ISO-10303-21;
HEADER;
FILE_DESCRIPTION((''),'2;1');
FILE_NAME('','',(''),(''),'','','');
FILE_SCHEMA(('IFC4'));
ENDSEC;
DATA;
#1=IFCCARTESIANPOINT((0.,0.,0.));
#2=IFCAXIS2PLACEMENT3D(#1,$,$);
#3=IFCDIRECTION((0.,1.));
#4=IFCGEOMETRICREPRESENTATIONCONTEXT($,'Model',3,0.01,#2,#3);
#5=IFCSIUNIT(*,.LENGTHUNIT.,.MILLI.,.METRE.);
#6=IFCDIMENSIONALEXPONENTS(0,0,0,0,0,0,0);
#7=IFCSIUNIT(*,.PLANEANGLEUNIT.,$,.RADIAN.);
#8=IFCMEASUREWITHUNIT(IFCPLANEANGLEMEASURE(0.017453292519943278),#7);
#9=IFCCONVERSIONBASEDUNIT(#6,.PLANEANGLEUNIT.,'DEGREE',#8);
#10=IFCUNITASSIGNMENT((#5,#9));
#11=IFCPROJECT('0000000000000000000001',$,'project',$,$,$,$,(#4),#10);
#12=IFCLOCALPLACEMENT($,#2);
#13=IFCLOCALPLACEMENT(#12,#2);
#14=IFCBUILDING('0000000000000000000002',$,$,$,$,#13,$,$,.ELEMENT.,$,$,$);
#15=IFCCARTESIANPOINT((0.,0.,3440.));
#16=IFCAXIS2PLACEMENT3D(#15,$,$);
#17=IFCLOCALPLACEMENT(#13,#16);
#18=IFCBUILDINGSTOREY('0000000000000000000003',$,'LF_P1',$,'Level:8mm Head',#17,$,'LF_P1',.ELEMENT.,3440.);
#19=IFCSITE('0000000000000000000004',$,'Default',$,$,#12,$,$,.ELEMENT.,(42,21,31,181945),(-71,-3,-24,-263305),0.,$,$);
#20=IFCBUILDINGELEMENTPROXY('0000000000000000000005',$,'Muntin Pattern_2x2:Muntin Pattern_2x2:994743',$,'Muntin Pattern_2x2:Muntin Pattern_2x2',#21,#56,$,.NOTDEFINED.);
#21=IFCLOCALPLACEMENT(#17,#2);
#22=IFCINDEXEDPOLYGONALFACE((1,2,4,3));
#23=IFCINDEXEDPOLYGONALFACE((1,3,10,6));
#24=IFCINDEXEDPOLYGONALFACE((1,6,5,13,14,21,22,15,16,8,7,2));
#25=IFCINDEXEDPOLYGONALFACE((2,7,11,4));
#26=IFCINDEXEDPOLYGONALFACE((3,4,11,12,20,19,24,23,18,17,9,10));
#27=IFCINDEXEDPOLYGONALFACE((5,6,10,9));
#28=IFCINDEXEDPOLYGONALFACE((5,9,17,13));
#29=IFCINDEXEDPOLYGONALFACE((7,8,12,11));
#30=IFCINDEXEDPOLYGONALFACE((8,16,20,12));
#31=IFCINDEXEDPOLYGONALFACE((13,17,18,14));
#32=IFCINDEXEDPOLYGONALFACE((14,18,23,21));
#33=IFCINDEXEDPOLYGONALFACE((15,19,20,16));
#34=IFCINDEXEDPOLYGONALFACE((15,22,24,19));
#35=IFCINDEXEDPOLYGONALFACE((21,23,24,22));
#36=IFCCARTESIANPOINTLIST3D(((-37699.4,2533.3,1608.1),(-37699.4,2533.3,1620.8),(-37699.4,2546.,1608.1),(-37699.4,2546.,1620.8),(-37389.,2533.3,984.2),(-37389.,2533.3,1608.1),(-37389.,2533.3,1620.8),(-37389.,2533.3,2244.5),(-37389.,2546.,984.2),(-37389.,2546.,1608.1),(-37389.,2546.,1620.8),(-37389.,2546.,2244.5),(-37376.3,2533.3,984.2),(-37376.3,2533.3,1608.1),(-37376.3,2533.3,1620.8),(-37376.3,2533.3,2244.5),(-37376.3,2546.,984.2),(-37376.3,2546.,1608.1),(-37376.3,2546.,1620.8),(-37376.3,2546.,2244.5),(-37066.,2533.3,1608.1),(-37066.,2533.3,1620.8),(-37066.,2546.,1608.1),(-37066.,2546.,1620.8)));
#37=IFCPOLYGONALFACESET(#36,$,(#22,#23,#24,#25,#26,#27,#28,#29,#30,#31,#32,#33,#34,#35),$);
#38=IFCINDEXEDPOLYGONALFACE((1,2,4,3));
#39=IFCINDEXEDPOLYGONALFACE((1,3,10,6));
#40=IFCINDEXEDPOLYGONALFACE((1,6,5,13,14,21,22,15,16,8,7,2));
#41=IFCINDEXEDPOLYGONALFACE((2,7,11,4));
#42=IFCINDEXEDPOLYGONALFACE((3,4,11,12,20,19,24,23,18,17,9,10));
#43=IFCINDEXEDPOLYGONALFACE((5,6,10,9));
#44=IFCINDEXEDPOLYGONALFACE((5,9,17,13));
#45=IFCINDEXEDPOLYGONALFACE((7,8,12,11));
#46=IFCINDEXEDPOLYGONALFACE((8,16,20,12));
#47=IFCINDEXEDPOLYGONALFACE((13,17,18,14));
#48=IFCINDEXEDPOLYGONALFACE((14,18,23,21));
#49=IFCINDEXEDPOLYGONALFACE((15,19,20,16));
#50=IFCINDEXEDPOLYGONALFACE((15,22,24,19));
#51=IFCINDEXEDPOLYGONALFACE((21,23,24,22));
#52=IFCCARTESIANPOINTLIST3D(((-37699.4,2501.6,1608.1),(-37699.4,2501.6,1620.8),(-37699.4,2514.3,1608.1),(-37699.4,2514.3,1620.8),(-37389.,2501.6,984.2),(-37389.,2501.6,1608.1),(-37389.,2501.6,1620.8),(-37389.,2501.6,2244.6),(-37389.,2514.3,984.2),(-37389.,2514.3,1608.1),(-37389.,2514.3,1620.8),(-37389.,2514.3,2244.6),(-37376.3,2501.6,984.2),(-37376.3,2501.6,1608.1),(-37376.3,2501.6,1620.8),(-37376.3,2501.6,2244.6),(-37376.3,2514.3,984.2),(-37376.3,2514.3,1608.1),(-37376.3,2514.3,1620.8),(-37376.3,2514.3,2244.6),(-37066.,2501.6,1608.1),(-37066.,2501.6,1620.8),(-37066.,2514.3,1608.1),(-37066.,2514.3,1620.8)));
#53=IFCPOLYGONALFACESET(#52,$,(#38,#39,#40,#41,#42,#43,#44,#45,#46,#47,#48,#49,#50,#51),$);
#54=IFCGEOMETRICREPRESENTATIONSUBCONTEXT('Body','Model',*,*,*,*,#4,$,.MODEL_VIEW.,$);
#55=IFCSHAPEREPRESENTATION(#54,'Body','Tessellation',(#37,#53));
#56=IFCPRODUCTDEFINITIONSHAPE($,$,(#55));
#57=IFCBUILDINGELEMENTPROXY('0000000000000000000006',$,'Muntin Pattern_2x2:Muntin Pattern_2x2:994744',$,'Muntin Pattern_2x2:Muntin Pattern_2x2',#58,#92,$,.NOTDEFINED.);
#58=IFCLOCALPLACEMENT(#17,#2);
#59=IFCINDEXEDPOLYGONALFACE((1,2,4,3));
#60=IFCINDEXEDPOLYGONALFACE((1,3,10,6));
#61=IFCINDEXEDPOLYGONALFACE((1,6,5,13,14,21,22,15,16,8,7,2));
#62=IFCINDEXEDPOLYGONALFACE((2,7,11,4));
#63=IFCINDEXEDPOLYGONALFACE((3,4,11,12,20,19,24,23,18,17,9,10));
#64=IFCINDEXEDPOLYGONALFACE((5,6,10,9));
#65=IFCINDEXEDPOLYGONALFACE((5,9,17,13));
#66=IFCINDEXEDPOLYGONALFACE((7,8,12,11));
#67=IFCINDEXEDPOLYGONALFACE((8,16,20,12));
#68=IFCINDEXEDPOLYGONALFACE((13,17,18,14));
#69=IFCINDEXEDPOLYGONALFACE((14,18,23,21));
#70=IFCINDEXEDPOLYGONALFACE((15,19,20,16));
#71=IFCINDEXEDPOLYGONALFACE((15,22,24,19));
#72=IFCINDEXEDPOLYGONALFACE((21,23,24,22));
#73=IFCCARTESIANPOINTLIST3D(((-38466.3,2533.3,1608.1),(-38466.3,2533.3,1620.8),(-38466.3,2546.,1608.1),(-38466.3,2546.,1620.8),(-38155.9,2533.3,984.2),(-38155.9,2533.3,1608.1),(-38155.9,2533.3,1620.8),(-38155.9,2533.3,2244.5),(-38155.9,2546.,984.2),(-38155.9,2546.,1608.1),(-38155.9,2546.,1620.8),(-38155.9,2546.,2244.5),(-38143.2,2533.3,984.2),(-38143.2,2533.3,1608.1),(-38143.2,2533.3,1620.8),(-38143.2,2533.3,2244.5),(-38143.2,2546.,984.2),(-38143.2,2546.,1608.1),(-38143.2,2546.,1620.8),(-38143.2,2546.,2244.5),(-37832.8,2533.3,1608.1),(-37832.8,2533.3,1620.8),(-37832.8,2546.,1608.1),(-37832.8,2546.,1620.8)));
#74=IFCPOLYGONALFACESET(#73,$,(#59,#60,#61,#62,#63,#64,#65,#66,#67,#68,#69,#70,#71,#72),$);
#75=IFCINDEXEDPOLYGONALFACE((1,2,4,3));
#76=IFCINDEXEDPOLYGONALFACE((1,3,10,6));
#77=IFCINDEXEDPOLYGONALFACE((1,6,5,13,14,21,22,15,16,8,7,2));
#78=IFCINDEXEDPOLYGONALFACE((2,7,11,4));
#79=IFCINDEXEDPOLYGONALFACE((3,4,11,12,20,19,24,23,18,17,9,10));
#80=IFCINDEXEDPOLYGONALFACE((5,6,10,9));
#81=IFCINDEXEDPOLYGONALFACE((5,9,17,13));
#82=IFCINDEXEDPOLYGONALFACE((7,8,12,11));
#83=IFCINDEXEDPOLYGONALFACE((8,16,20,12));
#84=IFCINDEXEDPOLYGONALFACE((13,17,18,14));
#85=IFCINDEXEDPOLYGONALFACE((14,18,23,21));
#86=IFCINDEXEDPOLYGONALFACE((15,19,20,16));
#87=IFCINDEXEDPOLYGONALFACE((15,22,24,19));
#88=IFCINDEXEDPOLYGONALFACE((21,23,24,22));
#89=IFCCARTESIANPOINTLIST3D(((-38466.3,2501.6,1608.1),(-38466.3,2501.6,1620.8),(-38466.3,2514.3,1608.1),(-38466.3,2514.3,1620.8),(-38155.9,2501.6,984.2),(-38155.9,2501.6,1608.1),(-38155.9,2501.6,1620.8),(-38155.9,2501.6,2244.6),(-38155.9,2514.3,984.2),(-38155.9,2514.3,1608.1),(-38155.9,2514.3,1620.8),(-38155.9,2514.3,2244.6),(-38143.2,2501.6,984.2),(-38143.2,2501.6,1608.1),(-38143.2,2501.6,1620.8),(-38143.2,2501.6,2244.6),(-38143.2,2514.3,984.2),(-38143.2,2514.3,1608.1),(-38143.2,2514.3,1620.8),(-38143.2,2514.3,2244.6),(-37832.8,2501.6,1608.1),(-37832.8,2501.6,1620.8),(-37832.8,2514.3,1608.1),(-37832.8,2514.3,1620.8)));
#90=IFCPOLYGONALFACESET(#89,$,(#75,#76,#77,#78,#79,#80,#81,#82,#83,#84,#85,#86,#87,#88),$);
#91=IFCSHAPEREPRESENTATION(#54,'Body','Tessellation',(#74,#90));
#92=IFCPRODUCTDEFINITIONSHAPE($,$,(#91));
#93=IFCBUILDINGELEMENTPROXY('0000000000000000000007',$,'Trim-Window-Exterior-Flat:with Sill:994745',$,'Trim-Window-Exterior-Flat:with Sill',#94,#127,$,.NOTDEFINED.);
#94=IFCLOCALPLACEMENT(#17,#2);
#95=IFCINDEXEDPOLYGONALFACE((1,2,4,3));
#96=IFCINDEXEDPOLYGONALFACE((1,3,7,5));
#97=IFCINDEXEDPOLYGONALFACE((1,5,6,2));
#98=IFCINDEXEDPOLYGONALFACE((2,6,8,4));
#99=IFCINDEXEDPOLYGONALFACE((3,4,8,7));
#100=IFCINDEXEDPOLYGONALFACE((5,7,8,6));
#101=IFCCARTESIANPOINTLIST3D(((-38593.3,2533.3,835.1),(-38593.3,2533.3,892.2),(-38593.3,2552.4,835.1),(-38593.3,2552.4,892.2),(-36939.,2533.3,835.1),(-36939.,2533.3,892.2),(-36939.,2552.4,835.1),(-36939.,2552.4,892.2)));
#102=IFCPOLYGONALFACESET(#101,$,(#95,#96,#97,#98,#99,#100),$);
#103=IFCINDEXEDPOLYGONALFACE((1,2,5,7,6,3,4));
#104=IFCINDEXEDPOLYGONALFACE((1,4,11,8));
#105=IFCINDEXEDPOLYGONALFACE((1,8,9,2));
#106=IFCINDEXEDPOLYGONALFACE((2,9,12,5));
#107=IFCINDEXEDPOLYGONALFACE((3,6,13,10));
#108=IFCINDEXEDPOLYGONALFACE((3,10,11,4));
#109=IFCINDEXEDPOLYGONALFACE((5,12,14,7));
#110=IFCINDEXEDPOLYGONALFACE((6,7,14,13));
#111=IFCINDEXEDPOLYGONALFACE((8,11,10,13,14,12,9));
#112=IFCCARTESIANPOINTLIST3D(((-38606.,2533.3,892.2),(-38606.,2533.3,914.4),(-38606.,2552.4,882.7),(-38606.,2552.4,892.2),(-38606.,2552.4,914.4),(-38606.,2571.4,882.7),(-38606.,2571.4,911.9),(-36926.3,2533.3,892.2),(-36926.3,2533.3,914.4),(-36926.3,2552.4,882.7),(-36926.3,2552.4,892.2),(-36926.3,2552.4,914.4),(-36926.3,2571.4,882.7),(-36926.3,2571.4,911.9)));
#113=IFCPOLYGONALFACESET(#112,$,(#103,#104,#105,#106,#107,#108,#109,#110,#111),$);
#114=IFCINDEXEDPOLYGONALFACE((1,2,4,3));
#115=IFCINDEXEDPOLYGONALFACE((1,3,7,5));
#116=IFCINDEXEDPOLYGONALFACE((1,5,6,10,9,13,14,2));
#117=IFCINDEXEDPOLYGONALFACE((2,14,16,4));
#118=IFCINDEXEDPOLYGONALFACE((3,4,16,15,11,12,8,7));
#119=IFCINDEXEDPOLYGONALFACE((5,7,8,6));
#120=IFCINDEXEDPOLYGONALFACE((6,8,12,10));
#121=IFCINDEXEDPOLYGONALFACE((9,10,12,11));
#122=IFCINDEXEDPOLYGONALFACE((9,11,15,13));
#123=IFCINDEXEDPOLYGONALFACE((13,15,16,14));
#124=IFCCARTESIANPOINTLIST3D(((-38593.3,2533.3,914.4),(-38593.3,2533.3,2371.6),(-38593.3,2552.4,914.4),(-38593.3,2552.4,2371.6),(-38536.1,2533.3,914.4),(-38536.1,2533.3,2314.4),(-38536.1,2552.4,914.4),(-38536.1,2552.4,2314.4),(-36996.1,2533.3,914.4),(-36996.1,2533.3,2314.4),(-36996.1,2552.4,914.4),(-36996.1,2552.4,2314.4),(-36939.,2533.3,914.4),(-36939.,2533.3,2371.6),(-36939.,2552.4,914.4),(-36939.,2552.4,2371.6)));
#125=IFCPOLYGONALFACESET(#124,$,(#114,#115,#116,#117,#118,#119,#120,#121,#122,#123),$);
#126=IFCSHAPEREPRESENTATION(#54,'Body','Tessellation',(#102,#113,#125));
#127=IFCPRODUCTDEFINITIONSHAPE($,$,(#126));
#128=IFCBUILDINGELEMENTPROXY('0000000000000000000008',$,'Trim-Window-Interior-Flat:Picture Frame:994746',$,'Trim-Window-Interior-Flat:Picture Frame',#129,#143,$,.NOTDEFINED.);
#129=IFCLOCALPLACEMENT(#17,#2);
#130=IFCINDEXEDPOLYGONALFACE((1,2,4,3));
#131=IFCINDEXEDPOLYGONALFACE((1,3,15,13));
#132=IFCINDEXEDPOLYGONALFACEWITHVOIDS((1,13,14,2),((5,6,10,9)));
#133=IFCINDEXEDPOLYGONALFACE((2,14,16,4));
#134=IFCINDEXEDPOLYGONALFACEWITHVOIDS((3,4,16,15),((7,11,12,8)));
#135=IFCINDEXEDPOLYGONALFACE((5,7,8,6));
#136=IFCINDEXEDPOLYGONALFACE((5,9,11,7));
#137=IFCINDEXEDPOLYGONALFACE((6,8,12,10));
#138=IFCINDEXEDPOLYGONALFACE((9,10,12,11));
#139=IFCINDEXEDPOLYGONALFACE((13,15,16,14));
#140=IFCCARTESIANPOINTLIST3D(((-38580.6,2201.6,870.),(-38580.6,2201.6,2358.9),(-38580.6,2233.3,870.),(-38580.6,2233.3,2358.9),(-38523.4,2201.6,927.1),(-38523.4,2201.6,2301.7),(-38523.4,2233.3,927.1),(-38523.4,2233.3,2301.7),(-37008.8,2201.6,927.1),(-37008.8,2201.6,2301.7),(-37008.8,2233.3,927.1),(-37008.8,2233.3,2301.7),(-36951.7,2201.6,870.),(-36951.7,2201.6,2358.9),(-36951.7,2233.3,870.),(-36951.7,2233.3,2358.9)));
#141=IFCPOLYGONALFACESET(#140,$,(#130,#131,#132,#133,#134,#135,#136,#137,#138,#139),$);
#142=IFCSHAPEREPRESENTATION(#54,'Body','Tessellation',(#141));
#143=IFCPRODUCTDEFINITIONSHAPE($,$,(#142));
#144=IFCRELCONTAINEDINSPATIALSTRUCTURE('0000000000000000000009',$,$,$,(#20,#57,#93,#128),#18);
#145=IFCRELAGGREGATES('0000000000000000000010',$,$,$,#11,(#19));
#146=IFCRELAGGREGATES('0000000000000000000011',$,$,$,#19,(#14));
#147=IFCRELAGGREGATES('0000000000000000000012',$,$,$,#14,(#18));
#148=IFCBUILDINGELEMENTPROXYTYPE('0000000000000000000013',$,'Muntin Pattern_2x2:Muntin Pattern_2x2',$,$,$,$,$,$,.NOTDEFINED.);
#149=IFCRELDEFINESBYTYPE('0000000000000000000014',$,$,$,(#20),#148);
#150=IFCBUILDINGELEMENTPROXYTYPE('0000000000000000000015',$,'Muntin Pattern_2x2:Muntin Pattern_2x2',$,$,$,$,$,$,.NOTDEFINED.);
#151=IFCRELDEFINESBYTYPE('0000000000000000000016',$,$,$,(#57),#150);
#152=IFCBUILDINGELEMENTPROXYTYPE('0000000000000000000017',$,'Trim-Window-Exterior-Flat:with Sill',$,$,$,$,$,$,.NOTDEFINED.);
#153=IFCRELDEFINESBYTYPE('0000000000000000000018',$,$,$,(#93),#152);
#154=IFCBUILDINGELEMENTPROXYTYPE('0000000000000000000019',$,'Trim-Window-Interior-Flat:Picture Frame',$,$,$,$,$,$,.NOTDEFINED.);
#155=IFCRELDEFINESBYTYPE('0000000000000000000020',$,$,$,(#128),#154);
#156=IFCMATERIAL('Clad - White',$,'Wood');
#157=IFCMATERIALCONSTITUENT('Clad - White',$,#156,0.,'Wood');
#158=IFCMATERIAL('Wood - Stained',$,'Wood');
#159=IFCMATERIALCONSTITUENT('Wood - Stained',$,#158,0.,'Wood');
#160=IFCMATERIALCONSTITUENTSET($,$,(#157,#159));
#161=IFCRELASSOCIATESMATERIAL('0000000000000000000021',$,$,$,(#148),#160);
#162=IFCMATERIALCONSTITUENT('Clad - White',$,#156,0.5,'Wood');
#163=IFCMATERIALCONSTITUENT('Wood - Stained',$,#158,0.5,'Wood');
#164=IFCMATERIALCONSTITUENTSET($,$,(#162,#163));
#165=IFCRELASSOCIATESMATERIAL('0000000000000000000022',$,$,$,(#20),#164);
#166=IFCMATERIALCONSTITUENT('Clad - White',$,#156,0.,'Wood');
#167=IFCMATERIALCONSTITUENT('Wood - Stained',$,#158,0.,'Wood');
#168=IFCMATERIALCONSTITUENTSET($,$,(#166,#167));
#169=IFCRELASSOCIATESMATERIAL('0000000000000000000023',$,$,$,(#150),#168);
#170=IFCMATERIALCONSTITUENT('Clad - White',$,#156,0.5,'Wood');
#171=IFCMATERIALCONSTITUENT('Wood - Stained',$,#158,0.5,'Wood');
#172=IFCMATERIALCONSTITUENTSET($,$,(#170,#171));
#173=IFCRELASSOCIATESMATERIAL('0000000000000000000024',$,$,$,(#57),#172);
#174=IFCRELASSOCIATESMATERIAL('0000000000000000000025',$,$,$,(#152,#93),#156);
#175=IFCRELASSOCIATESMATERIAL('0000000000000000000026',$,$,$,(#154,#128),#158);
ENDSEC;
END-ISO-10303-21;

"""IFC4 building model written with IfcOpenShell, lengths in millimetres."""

from ifc_helpers import new_model, entity, si_unit, converted_unit, direction, frame, origin, place, context, subcontext, project, spatial, indexed_curve, outline, extrude, source, transform, mapped, material, constituent, constituent_set, type_object, type_shapes, element, save


model = new_model("IFC4")

# Units and contexts
model_context = context("Model", 3, precision=0.01, world=origin(), true_north=direction((0.0, 1.0)))
body_context = subcontext(model_context, "Body", "Model", "MODEL_VIEW")
ifc_project = project(units=[si_unit("LENGTHUNIT", "METRE", prefix="MILLI"), converted_unit("PLANEANGLEUNIT", "DEGREE", entity("IfcPlaneAngleMeasure", 0.017453292519943278), si_unit("PLANEANGLEUNIT", "RADIAN"), dimensions=[0, 0, 0, 0, 0, 0, 0])], contexts=[model_context])

# Site, building, storey
site_placement = place(None, origin())
site = spatial("IfcSite", under=ifc_project, at=site_placement, Name="Default", CompositionType="ELEMENT", RefLatitude=(42, 21, 31, 181945), RefLongitude=(-71, -3, -24, -263305), RefElevation=0.0)
building_placement = place(site_placement, origin())
building = spatial("IfcBuilding", under=site, at=building_placement, CompositionType="ELEMENT")
storey_placement = place(building_placement, frame((0.0, 0.0, 3440.0)))
storey = spatial("IfcBuildingStorey", under=building, at=storey_placement, Name="LF_P1", ObjectType="Level:8mm Head", LongName="LF_P1", CompositionType="ELEMENT", Elevation=3440.0)

# Building element proxies
ifc_material_1 = material(Name="Clad - White", Category="Wood")
ifc_constituent_1 = constituent(ifc_material_1, Name="Clad - White", Category="Wood", fraction=0.5)
ifc_material_2 = material(Name="Wood - Stained", Category="Wood")
ifc_constituent_2 = constituent(ifc_material_2, Name="Wood - Stained", Category="Wood", fraction=0.5)
ifc_constituent_set_1 = constituent_set(constituents=[ifc_constituent_1, ifc_constituent_2])
ifc_constituent_3 = constituent(ifc_material_1, Name="Clad - White", Category="Wood", fraction=0.0)
ifc_constituent_4 = constituent(ifc_material_2, Name="Wood - Stained", Category="Wood", fraction=0.0)
ifc_constituent_set_2 = constituent_set(constituents=[ifc_constituent_3, ifc_constituent_4])
building_element_proxy_type_1 = type_object("IfcBuildingElementProxyType", Name="Muntin Pattern_2x2:Muntin Pattern_2x2", PredefinedType="NOTDEFINED", material=ifc_constituent_set_2)
shared_shape_1 = source(origin(), body_context, "Body", "SweptSolid", [
    extrude(outline(indexed_curve([(6.4, -6.4), (630.1, -6.4), (630.1, 6.3), (6.4, 6.3), (6.4, 316.7), (-6.3, 316.7), (-6.3, 6.3), (-630.2, 6.3), (-630.2, -6.4), (-6.3, -6.4), (-6.3, -316.7), (6.4, -316.7), (6.4, -6.4)], self_intersect=False)), frame((0.0, -22.2, 630.1), z_axis=(0.0, 1.0, 0.0), x_axis=(0.0, 0.0, 1.0)), (0.0, 0.0, 1.0), 12.7),
    extrude(outline(indexed_curve([(6.4, -6.4), (630.2, -6.4), (630.2, 6.3), (6.4, 6.3), (6.4, 316.7), (-6.3, 316.7), (-6.3, 6.3), (-630.2, 6.3), (-630.2, -6.4), (-6.3, -6.4), (-6.3, -316.7), (6.4, -316.7), (6.4, -6.4)], self_intersect=False)), frame((0.0, 9.5, 630.2), z_axis=(0.0, 1.0, 0.0), x_axis=(0.0, 0.0, 1.0)), (0.0, 0.0, 1.0), 12.7),
])
type_shapes(building_element_proxy_type_1, [shared_shape_1])
proxy_1_placement = place(storey_placement, frame((-37382.7, 2523.8, 984.3), z_axis=(0.0, 0.0, 1.0), x_axis=(-1.0, 0.0, 0.0)))
element("IfcBuildingElementProxy", 1, at=proxy_1_placement, inside=storey, type_object=building_element_proxy_type_1, material=ifc_constituent_set_1, Name="Muntin Pattern_2x2:Muntin Pattern_2x2:994743", ObjectType="Muntin Pattern_2x2:Muntin Pattern_2x2", PredefinedType="NOTDEFINED", context=body_context, shape_type="MappedRepresentation", body=[
    mapped(shared_shape_1, transform((0.0, 0.0, 0.0), scale=1.0)),
])
ifc_constituent_5 = constituent(ifc_material_1, Name="Clad - White", Category="Wood", fraction=0.5)
ifc_constituent_6 = constituent(ifc_material_2, Name="Wood - Stained", Category="Wood", fraction=0.5)
ifc_constituent_set_3 = constituent_set(constituents=[ifc_constituent_5, ifc_constituent_6])
ifc_constituent_7 = constituent(ifc_material_1, Name="Clad - White", Category="Wood", fraction=0.0)
ifc_constituent_8 = constituent(ifc_material_2, Name="Wood - Stained", Category="Wood", fraction=0.0)
ifc_constituent_set_4 = constituent_set(constituents=[ifc_constituent_7, ifc_constituent_8])
building_element_proxy_type_2 = type_object("IfcBuildingElementProxyType", Name="Muntin Pattern_2x2:Muntin Pattern_2x2", PredefinedType="NOTDEFINED", material=ifc_constituent_set_4)
shared_shape_2 = source(origin(), body_context, "Body", "SweptSolid", [
    extrude(outline(indexed_curve([(6.4, -6.4), (630.1, -6.4), (630.1, 6.3), (6.4, 6.3), (6.4, 316.7), (-6.3, 316.7), (-6.3, 6.3), (-630.2, 6.3), (-630.2, -6.4), (-6.3, -6.4), (-6.3, -316.7), (6.4, -316.7), (6.4, -6.4)], self_intersect=False)), frame((0.0, 9.5, 630.1), z_axis=(0.0, 1.0, 0.0), x_axis=(0.0, 0.0, 1.0)), (0.0, 0.0, 1.0), 12.7),
    extrude(outline(indexed_curve([(6.4, -6.4), (630.2, -6.4), (630.2, 6.3), (6.4, 6.3), (6.4, 316.7), (-6.3, 316.7), (-6.3, 6.3), (-630.2, 6.3), (-630.2, -6.4), (-6.3, -6.4), (-6.3, -316.7), (6.4, -316.7), (6.4, -6.4)], self_intersect=False)), frame((0.0, -22.2, 630.2), z_axis=(0.0, 1.0, 0.0), x_axis=(0.0, 0.0, 1.0)), (0.0, 0.0, 1.0), 12.7),
])
type_shapes(building_element_proxy_type_2, [shared_shape_2])
proxy_2_placement = place(storey_placement, frame((-38149.5, 2523.8, 984.3)))
element("IfcBuildingElementProxy", 2, at=proxy_2_placement, inside=storey, type_object=building_element_proxy_type_2, material=ifc_constituent_set_3, Name="Muntin Pattern_2x2:Muntin Pattern_2x2:994744", ObjectType="Muntin Pattern_2x2:Muntin Pattern_2x2", PredefinedType="NOTDEFINED", context=body_context, shape_type="MappedRepresentation", body=[
    mapped(shared_shape_2, transform((0.0, 0.0, 0.0), scale=1.0)),
])
building_element_proxy_type_3 = type_object("IfcBuildingElementProxyType", Name="Trim-Window-Exterior-Flat:with Sill", PredefinedType="NOTDEFINED", material=ifc_material_1)
shared_shape_3 = source(origin(), body_context, "Body", "SweptSolid", [
    extrude(outline(indexed_curve([(-28.6, -827.1), (28.6, -827.1), (28.6, 827.1), (-28.6, 827.1), (-28.6, -827.1)], self_intersect=False)), frame((0.0, 1450.8, 0.0), z_axis=(0.0, 0.0, 1.0), x_axis=(0.0, 1.0, 0.0)), (0.0, 0.0, 1.0), 19.0),
    extrude(outline(indexed_curve([(-16.0, -19.0), (13.3, -19.0), (15.8, 0.0), (15.8, 19.0), (-6.4, 19.0), (-6.4, 0.0), (-16.0, 0.0), (-16.0, -19.0)], self_intersect=False)), frame((-839.8, 1415.8, 19.0), z_axis=(1.0, 0.0, 0.0), x_axis=(0.0, -1.0, 0.0)), (0.0, 0.0, 1.0), 1679.7),
    extrude(outline(indexed_curve([(-827.1, -742.9), (827.1, -742.9), (827.1, 714.3), (770.0, 714.3), (770.0, -685.7), (-770.0, -685.7), (-770.0, 714.3), (-827.1, 714.3), (-827.1, -742.9)], self_intersect=False)), frame((0.0, 685.7, 0.0)), (0.0, 0.0, 1.0), 19.0),
])
type_shapes(building_element_proxy_type_3, [shared_shape_3])
proxy_3_placement = place(storey_placement, frame((-37766.1, 2533.3, 2314.4), z_axis=(0.0, 1.0, 0.0), x_axis=(1.0, 0.0, 0.0)))
element("IfcBuildingElementProxy", 3, at=proxy_3_placement, inside=storey, type_object=building_element_proxy_type_3, material=ifc_material_1, Name="Trim-Window-Exterior-Flat:with Sill:994745", ObjectType="Trim-Window-Exterior-Flat:with Sill", PredefinedType="NOTDEFINED", context=body_context, shape_type="MappedRepresentation", body=[
    mapped(shared_shape_3, transform((0.0, 0.0, 0.0), scale=1.0)),
])
building_element_proxy_type_4 = type_object("IfcBuildingElementProxyType", Name="Trim-Window-Interior-Flat:Picture Frame", PredefinedType="NOTDEFINED", material=ifc_material_2)
shared_shape_4 = source(origin(), body_context, "Body", "SweptSolid", [
    extrude(outline(indexed_curve([(-744.4, -814.4), (744.4, -814.4), (744.4, 814.4), (-744.4, 814.4), (-744.4, -814.4)], self_intersect=False), holes=[indexed_curve([(-687.3, -757.3), (-687.3, 757.3), (687.3, 757.3), (687.3, -757.3), (-687.3, -757.3)], self_intersect=False)]), frame((0.0, 700.0, 0.0), z_axis=(0.0, 0.0, 1.0), x_axis=(0.0, 1.0, 0.0)), (0.0, 0.0, 1.0), 31.7),
])
type_shapes(building_element_proxy_type_4, [shared_shape_4])
proxy_4_placement = place(storey_placement, frame((-37766.1, 2233.3, 2314.4), z_axis=(0.0, -1.0, 0.0), x_axis=(-1.0, 0.0, 0.0)))
element("IfcBuildingElementProxy", 4, at=proxy_4_placement, inside=storey, type_object=building_element_proxy_type_4, material=ifc_material_2, Name="Trim-Window-Interior-Flat:Picture Frame:994746", ObjectType="Trim-Window-Interior-Flat:Picture Frame", PredefinedType="NOTDEFINED", context=body_context, shape_type="MappedRepresentation", body=[
    mapped(shared_shape_4, transform((0.0, 0.0, 0.0), scale=1.0)),
])

save(model, "model.ifc")
